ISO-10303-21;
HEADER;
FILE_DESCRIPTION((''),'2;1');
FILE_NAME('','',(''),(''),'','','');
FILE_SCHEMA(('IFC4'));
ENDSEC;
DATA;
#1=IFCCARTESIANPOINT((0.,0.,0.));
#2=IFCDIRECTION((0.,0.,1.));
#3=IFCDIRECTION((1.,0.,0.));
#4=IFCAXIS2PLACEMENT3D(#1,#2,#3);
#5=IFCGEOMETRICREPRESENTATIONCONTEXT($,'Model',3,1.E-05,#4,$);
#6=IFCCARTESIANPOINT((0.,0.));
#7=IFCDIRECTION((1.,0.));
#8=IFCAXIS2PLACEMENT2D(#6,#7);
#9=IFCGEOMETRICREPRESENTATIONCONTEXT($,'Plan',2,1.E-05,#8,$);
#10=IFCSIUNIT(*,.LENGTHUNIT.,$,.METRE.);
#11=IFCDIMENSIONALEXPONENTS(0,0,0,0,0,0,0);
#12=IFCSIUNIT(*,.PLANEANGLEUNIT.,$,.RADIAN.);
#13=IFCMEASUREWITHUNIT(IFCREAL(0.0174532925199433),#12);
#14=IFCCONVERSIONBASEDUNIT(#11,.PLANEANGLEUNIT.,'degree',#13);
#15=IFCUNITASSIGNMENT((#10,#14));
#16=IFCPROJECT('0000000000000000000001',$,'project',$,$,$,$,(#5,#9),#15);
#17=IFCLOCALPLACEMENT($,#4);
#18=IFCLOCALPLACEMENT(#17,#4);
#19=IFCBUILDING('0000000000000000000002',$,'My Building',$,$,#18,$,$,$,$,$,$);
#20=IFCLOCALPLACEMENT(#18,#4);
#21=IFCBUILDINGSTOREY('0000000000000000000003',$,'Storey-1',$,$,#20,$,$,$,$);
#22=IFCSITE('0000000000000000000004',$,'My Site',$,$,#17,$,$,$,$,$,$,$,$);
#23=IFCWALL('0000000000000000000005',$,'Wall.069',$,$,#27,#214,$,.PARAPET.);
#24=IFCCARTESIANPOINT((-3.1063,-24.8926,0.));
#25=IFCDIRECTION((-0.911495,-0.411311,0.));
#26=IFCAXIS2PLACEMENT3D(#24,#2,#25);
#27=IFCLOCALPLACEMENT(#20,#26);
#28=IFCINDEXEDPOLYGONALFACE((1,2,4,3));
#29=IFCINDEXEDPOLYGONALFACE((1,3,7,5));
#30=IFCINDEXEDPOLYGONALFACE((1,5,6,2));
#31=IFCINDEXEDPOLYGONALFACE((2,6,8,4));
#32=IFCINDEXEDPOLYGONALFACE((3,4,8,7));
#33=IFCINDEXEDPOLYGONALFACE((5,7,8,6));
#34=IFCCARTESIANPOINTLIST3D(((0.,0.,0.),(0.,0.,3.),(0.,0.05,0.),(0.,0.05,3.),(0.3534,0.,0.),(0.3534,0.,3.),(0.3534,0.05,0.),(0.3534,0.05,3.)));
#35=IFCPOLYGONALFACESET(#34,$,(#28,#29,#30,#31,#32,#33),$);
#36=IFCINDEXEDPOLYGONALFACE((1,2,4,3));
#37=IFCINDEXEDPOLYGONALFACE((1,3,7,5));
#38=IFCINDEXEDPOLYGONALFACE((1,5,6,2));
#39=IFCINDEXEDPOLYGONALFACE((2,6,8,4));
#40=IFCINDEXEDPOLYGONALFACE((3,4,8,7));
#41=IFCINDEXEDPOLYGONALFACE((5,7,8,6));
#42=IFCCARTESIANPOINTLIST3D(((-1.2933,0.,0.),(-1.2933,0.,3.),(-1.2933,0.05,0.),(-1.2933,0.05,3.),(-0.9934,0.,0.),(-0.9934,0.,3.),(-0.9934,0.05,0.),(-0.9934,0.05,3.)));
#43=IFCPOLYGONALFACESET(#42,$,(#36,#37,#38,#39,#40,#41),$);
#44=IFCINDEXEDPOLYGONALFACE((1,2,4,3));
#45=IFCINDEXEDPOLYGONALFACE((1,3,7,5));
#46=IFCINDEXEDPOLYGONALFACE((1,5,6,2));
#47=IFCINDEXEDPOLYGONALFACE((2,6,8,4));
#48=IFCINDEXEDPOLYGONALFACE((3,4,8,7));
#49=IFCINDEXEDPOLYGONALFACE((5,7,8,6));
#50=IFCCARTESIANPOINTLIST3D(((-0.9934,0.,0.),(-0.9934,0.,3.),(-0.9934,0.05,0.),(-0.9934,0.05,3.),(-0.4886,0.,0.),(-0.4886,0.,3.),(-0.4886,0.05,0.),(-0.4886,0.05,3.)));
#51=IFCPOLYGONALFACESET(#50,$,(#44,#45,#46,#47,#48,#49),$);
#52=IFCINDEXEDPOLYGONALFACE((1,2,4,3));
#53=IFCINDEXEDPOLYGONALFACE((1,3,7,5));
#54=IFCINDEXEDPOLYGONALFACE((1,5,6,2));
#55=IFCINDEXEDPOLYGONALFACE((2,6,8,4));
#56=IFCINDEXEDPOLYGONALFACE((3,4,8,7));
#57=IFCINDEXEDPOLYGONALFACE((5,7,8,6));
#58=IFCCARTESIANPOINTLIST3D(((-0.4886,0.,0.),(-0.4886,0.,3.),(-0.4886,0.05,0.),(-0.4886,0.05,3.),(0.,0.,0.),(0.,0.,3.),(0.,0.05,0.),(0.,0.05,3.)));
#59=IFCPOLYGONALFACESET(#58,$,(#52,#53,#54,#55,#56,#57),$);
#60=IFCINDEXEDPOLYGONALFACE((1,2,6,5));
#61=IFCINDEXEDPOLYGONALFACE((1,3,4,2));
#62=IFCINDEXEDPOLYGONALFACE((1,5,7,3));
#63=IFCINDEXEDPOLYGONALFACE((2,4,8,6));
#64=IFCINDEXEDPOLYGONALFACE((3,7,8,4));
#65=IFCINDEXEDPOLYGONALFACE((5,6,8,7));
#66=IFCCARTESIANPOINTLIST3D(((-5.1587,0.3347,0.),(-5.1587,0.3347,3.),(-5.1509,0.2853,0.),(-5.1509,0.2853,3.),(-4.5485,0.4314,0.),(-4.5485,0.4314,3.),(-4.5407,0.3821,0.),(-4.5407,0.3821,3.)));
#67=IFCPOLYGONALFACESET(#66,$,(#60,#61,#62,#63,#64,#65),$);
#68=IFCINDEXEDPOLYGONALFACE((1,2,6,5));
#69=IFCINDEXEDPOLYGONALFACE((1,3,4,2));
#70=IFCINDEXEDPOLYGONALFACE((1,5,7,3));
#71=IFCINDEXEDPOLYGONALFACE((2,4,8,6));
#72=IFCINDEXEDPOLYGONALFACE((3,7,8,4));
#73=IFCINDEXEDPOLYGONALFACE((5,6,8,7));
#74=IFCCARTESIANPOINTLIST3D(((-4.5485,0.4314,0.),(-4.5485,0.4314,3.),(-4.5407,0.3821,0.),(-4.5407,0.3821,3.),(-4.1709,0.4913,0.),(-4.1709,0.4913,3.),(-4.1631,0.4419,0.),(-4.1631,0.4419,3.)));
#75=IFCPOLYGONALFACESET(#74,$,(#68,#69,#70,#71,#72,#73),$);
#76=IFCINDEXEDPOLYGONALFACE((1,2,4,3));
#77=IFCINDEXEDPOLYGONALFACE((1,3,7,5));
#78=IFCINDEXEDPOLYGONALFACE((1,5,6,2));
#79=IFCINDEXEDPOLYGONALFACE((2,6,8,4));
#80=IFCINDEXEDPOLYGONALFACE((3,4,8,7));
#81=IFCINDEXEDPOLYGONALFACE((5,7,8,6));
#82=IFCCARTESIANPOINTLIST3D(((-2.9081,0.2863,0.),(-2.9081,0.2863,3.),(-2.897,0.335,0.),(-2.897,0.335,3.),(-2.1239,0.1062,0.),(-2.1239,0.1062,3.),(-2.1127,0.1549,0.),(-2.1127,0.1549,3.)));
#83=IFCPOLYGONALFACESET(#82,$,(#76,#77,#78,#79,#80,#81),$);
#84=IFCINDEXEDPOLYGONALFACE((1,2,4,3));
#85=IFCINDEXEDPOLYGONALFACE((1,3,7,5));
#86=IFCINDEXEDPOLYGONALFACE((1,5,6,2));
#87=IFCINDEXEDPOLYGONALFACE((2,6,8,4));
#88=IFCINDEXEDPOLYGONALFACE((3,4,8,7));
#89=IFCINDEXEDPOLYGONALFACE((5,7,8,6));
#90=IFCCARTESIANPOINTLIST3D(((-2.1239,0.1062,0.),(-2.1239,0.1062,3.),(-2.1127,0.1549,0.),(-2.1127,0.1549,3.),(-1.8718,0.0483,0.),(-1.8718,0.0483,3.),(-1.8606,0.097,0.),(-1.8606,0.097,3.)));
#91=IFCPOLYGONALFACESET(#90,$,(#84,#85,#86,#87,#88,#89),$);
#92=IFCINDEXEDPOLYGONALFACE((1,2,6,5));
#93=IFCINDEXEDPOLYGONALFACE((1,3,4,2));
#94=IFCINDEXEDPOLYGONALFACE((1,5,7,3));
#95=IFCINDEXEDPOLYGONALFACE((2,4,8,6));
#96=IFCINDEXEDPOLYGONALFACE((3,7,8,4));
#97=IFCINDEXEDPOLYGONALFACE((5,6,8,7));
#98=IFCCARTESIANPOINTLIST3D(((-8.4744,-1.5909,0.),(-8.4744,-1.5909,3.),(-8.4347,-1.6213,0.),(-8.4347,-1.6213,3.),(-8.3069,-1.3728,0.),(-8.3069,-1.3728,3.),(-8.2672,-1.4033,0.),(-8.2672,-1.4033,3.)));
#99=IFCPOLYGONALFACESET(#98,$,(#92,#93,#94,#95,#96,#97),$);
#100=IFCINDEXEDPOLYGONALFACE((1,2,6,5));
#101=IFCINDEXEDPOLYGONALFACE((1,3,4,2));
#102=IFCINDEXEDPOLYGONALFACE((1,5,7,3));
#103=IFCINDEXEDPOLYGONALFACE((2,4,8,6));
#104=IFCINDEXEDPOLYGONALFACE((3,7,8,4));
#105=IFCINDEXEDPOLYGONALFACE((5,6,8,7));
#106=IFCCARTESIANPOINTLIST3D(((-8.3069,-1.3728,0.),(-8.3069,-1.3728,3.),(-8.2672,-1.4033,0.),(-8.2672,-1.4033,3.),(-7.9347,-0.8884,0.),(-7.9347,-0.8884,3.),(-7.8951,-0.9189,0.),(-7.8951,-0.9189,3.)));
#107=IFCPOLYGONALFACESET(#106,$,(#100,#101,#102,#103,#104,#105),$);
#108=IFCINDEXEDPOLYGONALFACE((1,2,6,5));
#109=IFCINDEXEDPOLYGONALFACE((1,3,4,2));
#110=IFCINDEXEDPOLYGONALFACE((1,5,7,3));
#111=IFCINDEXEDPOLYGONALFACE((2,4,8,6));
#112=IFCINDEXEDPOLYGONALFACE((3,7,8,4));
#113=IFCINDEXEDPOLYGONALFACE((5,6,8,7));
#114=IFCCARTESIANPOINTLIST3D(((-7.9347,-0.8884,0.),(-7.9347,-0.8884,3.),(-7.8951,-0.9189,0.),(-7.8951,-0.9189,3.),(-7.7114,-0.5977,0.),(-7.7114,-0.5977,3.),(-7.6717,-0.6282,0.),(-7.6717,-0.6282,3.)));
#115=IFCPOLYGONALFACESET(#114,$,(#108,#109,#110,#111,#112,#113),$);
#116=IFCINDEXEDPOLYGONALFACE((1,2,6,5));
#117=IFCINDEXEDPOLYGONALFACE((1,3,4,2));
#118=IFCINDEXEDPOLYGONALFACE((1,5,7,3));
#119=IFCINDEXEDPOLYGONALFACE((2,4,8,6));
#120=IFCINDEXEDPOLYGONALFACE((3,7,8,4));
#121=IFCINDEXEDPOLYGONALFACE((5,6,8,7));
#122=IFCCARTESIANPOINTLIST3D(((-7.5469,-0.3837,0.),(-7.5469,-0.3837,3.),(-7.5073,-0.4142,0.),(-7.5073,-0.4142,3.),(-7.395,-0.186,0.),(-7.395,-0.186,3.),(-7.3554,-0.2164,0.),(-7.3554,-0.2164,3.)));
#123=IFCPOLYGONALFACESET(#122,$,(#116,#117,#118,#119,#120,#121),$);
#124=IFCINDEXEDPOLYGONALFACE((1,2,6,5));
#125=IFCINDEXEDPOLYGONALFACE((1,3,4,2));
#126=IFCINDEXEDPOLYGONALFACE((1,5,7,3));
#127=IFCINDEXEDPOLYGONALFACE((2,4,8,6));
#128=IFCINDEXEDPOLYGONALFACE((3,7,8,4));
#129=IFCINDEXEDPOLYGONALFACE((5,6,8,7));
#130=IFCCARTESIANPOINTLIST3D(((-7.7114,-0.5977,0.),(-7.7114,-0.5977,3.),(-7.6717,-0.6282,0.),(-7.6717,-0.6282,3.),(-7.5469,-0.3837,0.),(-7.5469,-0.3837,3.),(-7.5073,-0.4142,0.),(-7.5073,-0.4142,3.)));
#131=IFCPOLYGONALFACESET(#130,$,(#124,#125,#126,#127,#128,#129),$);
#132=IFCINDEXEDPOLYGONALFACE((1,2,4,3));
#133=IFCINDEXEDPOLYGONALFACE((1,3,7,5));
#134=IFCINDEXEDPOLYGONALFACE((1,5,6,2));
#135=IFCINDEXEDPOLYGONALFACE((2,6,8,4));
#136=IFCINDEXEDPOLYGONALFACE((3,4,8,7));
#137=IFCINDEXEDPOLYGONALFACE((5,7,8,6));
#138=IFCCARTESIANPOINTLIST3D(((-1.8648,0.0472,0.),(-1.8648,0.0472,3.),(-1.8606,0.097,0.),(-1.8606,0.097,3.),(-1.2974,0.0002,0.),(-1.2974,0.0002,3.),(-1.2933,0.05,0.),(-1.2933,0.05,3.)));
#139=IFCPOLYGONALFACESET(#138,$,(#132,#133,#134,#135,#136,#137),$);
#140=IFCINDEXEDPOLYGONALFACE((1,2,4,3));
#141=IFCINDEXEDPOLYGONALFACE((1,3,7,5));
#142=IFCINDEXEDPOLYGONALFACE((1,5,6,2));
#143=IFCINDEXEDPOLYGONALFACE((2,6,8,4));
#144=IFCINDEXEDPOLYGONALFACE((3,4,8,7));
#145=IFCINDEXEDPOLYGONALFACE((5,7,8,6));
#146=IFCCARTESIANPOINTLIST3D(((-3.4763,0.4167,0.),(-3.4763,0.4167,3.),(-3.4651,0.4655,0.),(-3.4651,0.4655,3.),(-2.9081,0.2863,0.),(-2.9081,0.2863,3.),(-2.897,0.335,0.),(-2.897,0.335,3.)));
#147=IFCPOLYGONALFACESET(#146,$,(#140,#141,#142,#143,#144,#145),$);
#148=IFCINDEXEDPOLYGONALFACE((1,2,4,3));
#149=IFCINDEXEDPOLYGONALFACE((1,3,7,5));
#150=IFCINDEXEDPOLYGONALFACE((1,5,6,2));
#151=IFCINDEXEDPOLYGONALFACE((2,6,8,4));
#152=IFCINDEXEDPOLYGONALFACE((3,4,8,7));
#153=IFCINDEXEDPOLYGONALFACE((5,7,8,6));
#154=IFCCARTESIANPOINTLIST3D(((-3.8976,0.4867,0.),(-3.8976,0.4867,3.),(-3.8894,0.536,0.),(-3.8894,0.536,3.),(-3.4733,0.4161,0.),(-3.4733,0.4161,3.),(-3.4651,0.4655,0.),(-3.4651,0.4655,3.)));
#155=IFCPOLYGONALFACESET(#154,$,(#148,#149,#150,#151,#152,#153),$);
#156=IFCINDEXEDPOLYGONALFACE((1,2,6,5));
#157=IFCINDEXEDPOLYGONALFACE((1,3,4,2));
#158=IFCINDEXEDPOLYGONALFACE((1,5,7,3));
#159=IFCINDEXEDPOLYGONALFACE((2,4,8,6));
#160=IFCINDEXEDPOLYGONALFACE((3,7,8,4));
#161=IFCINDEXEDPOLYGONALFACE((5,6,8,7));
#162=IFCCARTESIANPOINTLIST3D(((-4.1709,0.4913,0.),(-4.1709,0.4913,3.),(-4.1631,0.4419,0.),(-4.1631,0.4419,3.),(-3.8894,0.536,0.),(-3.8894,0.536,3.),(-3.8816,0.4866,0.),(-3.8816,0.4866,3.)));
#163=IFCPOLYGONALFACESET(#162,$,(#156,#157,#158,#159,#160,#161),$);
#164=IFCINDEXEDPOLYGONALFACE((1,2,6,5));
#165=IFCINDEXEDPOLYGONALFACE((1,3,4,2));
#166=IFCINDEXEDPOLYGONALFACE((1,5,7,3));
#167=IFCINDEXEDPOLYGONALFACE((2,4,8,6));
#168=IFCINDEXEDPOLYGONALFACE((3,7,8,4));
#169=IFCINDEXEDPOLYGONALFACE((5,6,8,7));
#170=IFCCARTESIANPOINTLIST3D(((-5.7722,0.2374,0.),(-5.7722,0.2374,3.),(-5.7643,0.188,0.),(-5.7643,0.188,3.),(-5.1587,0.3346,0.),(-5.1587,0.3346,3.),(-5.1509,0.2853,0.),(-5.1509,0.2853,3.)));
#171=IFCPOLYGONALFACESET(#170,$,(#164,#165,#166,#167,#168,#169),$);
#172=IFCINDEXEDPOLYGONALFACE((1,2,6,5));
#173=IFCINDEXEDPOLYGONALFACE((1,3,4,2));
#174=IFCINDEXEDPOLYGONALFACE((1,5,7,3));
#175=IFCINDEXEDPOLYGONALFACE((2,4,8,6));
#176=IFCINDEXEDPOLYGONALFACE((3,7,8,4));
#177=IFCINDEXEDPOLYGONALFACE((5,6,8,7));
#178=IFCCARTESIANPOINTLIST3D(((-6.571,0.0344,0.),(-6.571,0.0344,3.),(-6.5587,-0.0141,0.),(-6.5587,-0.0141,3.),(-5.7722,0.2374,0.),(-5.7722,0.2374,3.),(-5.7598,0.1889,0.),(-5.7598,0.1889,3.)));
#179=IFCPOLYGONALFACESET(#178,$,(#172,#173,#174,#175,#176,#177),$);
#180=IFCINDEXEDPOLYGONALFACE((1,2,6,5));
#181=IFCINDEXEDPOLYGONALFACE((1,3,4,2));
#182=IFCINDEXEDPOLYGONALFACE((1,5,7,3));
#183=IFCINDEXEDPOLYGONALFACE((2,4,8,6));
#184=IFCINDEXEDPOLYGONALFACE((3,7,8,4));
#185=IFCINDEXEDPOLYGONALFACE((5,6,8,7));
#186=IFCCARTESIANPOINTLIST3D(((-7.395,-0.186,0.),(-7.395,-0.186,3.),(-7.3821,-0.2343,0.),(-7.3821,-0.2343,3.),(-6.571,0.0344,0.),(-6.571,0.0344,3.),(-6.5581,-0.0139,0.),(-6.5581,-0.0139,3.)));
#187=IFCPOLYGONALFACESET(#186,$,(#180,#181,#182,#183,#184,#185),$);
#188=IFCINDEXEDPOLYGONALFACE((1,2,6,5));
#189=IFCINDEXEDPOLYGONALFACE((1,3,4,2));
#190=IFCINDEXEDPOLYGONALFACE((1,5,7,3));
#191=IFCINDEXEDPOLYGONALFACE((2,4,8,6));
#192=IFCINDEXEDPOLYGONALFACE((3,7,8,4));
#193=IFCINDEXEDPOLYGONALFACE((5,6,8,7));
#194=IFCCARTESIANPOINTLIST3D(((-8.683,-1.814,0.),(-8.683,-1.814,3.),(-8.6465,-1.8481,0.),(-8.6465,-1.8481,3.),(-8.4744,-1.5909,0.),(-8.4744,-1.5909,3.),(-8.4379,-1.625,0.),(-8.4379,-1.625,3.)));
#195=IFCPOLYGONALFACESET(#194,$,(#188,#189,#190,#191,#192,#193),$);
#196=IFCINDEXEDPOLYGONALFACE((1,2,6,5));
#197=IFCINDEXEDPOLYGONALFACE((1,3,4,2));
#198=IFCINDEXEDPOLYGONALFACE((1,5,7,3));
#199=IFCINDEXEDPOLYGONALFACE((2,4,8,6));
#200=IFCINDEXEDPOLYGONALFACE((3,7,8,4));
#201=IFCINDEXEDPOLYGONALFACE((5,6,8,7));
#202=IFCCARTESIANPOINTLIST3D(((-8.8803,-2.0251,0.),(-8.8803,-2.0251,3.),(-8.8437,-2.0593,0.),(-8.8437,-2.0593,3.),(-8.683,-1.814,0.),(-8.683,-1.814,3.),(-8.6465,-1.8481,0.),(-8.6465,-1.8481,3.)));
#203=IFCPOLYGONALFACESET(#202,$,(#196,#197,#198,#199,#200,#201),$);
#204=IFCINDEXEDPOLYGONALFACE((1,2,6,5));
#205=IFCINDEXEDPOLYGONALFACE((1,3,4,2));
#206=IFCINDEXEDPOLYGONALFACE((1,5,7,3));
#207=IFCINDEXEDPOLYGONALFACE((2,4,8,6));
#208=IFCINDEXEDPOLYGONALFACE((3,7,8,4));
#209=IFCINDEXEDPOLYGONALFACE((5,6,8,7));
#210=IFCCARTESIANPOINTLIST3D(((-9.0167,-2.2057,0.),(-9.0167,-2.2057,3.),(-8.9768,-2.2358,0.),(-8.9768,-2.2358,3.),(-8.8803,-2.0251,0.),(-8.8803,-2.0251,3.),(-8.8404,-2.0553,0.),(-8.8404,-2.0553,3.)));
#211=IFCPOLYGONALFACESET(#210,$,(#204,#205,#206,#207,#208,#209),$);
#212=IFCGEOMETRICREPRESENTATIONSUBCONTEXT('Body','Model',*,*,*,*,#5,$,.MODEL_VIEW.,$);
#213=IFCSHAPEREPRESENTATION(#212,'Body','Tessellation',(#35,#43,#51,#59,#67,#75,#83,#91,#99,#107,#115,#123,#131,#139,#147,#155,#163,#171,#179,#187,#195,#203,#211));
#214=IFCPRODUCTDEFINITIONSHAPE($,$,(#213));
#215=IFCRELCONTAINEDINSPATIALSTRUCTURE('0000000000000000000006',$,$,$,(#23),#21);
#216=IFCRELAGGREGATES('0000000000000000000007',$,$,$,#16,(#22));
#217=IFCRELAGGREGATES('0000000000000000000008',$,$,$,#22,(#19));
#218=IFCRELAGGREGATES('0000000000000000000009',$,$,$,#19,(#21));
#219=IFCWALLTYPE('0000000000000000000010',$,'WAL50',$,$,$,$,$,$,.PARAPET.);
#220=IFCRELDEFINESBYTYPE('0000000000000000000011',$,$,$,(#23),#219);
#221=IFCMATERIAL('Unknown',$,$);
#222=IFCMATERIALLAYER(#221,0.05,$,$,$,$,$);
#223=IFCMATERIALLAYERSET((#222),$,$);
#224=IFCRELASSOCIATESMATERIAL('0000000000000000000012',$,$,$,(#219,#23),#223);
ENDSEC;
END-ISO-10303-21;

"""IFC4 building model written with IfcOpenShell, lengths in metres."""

from ifc_helpers import new_model, entity, si_unit, converted_unit, frame, origin_with_axes, origin_2d_with_axis, place, context, subcontext, project, spatial, indexed_curve, outline, extrude, material, layer, layer_set, layer_usage, type_object, element, save


model = new_model("IFC4")

# Units and contexts
model_context = context("Model", 3, precision=1e-05, world=origin_with_axes())
plan_context = context("Plan", 2, precision=1e-05, world=origin_2d_with_axis())
body_context = subcontext(model_context, "Body", "Model", "MODEL_VIEW")
ifc_project = project(units=[si_unit("LENGTHUNIT", "METRE"), converted_unit("PLANEANGLEUNIT", "degree", entity("IfcReal", 0.0174532925199433), si_unit("PLANEANGLEUNIT", "RADIAN"), dimensions=[0, 0, 0, 0, 0, 0, 0])], contexts=[model_context, plan_context])

# Site, building, storey
site_placement = place(None, origin_with_axes())
site = spatial("IfcSite", under=ifc_project, at=site_placement, Name="My Site")
building_placement = place(site_placement, origin_with_axes())
building = spatial("IfcBuilding", under=site, at=building_placement, Name="My Building")
storey_placement = place(building_placement, origin_with_axes())
storey = spatial("IfcBuildingStorey", under=building, at=storey_placement, Name="Storey-1")

# Shared definitions
ifc_material = material(Name="Unknown")

# Wall
ifc_layer_1 = layer(ifc_material, 0.05)
ifc_layer_set_1 = layer_set([ifc_layer_1])
ifc_layer_usage_1 = layer_usage(ifc_layer_set_1, "AXIS2", "POSITIVE", 0.0)
wall_type = type_object("IfcWallType", Name="WAL50", PredefinedType="PARAPET", material=ifc_layer_set_1)
wall_1_placement = place(storey_placement, frame((-3.1063, -24.8926, 0.0), z_axis=(0.0, 0.0, 1.0), x_axis=(-0.911495, -0.411311, 0.0)))
element("IfcWall", 1, at=wall_1_placement, inside=storey, type_object=wall_type, material=ifc_layer_usage_1, Name="Wall.069", PredefinedType="PARAPET", context=body_context, shape_type="SweptSolid", body=[
    extrude(outline(indexed_curve([(0.0, 0.0), (0.0, 0.05), (0.3534, 0.05), (0.3534, 0.0), (0.0, 0.0)], self_intersect=False)), origin_with_axes(), (0.0, 0.0, 1.0), 3.0),
    extrude(outline(indexed_curve([(0.0, 0.0), (0.0, 0.05), (0.2998, 0.05), (0.2998, 0.0), (0.0, 0.0)], self_intersect=False)), frame((-1.2933, 0.0, 0.0), z_axis=(0.0, 0.0, 1.0), x_axis=(1.0, 0.000003, 0.0)), (0.0, 0.0, 1.0), 3.0),
    extrude(outline(indexed_curve([(0.0, 0.0), (0.0, 0.05), (0.5048, 0.05), (0.5048, 0.0), (0.0, 0.0)], self_intersect=False)), frame((-0.9934, 0.0, 0.0), z_axis=(0.0, 0.0, 1.0), x_axis=(1.0, 0.000002, 0.0)), (0.0, 0.0, 1.0), 3.0),
    extrude(outline(indexed_curve([(0.0, 0.0), (0.0, 0.05), (0.4886, 0.05), (0.4886, 0.0), (0.0, 0.0)], self_intersect=False)), frame((-0.4886, 0.0, 0.0), z_axis=(0.0, 0.0, 1.0), x_axis=(1.0, 0.000003, 0.0)), (0.0, 0.0, 1.0), 3.0),
    extrude(outline(indexed_curve([(0.0, 0.0), (0.0, 0.05), (0.6179, 0.05), (0.6179, 0.0), (0.0, 0.0)], self_intersect=False)), frame((-5.1509, 0.2853, 0.0), z_axis=(0.0, 0.0, 1.0), x_axis=(0.987654, 0.15665, 0.0)), (0.0, 0.0, 1.0), 3.0),
    extrude(outline(indexed_curve([(0.0, 0.0), (0.0, 0.05), (0.3823, 0.05), (0.3823, 0.0), (0.0, 0.0)], self_intersect=False)), frame((-4.5407, 0.3821, 0.0), z_axis=(0.0, 0.0, 1.0), x_axis=(0.987653, 0.156655, 0.0)), (0.0, 0.0, 1.0), 3.0),
    extrude(outline(indexed_curve([(0.0, 0.0), (0.0, 0.05), (0.8047, 0.05), (0.8047, 0.0), (0.0, 0.0)], self_intersect=False)), frame((-2.9081, 0.2863, 0.0), z_axis=(0.0, 0.0, 1.0), x_axis=(0.974632, -0.223814, 0.0)), (0.0, 0.0, 1.0), 3.0),
    extrude(outline(indexed_curve([(0.0, 0.0), (0.0, 0.05), (0.2586, 0.05), (0.2586, 0.0), (0.0, 0.0)], self_intersect=False)), frame((-2.1239, 0.1062, 0.0), z_axis=(0.0, 0.0, 1.0), x_axis=(0.974633, -0.223808, 0.0)), (0.0, 0.0, 1.0), 3.0),
    extrude(outline(indexed_curve([(0.0, 0.0), (0.0, 0.05), (0.2749, 0.05), (0.2749, 0.0), (0.0, 0.0)], self_intersect=False)), frame((-8.4347, -1.6213, 0.0), z_axis=(0.0, 0.0, 1.0), x_axis=(0.609231, 0.792993, 0.0)), (0.0, 0.0, 1.0), 3.0),
    extrude(outline(indexed_curve([(0.0, 0.0), (0.0, 0.05), (0.6109, 0.05), (0.6109, 0.0), (0.0, 0.0)], self_intersect=False)), frame((-8.2672, -1.4033, 0.0), z_axis=(0.0, 0.0, 1.0), x_axis=(0.60923, 0.792993, 0.0)), (0.0, 0.0, 1.0), 3.0),
    extrude(outline(indexed_curve([(0.0, 0.0), (0.0, 0.05), (0.3666, 0.05), (0.3666, 0.0), (0.0, 0.0)], self_intersect=False)), frame((-7.8951, -0.9189, 0.0), z_axis=(0.0, 0.0, 1.0), x_axis=(0.609231, 0.792993, 0.0)), (0.0, 0.0, 1.0), 3.0),
    extrude(outline(indexed_curve([(0.0, 0.0), (0.0, 0.05), (0.2493, 0.05), (0.2493, 0.0), (0.0, 0.0)], self_intersect=False)), frame((-7.5073, -0.4142, 0.0), z_axis=(0.0, 0.0, 1.0), x_axis=(0.609231, 0.792993, 0.0)), (0.0, 0.0, 1.0), 3.0),
    extrude(outline(indexed_curve([(0.0, 0.0), (0.0, 0.05), (0.2699, 0.05), (0.2699, 0.0), (0.0, 0.0)], self_intersect=False)), frame((-7.6717, -0.6282, 0.0), z_axis=(0.0, 0.0, 1.0), x_axis=(0.60923, 0.792994, 0.0)), (0.0, 0.0, 1.0), 3.0),
    extrude(outline(indexed_curve([(0.0, 0.0), (0.0, 0.05), (0.5693, 0.05), (0.5693, 0.0), (0.0, 0.0)], self_intersect=False)), frame((-1.2933, 0.05, 0.0), z_axis=(0.0, 0.0, 1.0), x_axis=(-0.996582, 0.08261, 0.0)), (0.0, 0.0, 1.0), 3.0),
    extrude(outline(indexed_curve([(0.0, 0.0), (0.0, 0.05), (0.5829, 0.05), (0.5829, 0.0), (0.0, 0.0)], self_intersect=False)), frame((-2.897, 0.335, 0.0), z_axis=(0.0, 0.0, 1.0), x_axis=(-0.974633, 0.223808, 0.0)), (0.0, 0.0, 1.0), 3.0),
    extrude(outline(indexed_curve([(0.0, 0.0), (0.0, 0.05), (0.4301, 0.05), (0.4301, 0.0), (0.0, 0.0)], self_intersect=False)), frame((-3.4651, 0.4655, 0.0), z_axis=(0.0, 0.0, 1.0), x_axis=(-0.98647, 0.163945, 0.0)), (0.0, 0.0, 1.0), 3.0),
    extrude(outline(indexed_curve([(0.0, 0.0), (0.0, 0.05), (0.2851, 0.05), (0.2851, 0.0), (0.0, 0.0)], self_intersect=False)), frame((-3.8894, 0.536, 0.0), z_axis=(0.0, 0.0, 1.0), x_axis=(-0.987654, -0.156652, 0.0)), (0.0, 0.0, 1.0), 3.0),
    extrude(outline(indexed_curve([(0.0, 0.0), (0.0, 0.05), (0.6211, 0.05), (0.6211, 0.0), (0.0, 0.0)], self_intersect=False)), frame((-5.1587, 0.3346, 0.0), z_axis=(0.0, 0.0, 1.0), x_axis=(-0.987653, -0.156655, 0.0)), (0.0, 0.0, 1.0), 3.0),
    extrude(outline(indexed_curve([(0.0, 0.0), (0.0, 0.05), (0.8243, 0.05), (0.8243, 0.0), (0.0, 0.0)], self_intersect=False)), frame((-5.7722, 0.2374, 0.0), z_axis=(0.0, 0.0, 1.0), x_axis=(-0.969213, -0.246224, 0.0)), (0.0, 0.0, 1.0), 3.0),
    extrude(outline(indexed_curve([(0.0, 0.0), (0.0, 0.05), (0.853, 0.05), (0.853, 0.0), (0.0, 0.0)], self_intersect=False)), frame((-6.571, 0.0344, 0.0), z_axis=(0.0, 0.0, 1.0), x_axis=(-0.966044, -0.258379, 0.0)), (0.0, 0.0, 1.0), 3.0),
    extrude(outline(indexed_curve([(0.0, 0.0), (0.0, 0.05), (0.3055, 0.05), (0.3055, 0.0), (0.0, 0.0)], self_intersect=False)), frame((-8.4744, -1.5909, 0.0), z_axis=(0.0, 0.0, 1.0), x_axis=(-0.683108, -0.730317, 0.0)), (0.0, 0.0, 1.0), 3.0),
    extrude(outline(indexed_curve([(0.0, 0.0), (0.0, 0.05), (0.2889, 0.05), (0.2889, 0.0), (0.0, 0.0)], self_intersect=False)), frame((-8.683, -1.814, 0.0), z_axis=(0.0, 0.0, 1.0), x_axis=(-0.682552, -0.730837, 0.0)), (0.0, 0.0, 1.0), 3.0),
    extrude(outline(indexed_curve([(0.0, 0.0), (0.0, 0.05), (0.2263, 0.05), (0.2263, 0.0), (0.0, 0.0)], self_intersect=False)), frame((-8.8803, -2.0251, 0.0), z_axis=(0.0, 0.0, 1.0), x_axis=(-0.602935, -0.79779, 0.0)), (0.0, 0.0, 1.0), 3.0),
])

save(model, "model.ifc")
